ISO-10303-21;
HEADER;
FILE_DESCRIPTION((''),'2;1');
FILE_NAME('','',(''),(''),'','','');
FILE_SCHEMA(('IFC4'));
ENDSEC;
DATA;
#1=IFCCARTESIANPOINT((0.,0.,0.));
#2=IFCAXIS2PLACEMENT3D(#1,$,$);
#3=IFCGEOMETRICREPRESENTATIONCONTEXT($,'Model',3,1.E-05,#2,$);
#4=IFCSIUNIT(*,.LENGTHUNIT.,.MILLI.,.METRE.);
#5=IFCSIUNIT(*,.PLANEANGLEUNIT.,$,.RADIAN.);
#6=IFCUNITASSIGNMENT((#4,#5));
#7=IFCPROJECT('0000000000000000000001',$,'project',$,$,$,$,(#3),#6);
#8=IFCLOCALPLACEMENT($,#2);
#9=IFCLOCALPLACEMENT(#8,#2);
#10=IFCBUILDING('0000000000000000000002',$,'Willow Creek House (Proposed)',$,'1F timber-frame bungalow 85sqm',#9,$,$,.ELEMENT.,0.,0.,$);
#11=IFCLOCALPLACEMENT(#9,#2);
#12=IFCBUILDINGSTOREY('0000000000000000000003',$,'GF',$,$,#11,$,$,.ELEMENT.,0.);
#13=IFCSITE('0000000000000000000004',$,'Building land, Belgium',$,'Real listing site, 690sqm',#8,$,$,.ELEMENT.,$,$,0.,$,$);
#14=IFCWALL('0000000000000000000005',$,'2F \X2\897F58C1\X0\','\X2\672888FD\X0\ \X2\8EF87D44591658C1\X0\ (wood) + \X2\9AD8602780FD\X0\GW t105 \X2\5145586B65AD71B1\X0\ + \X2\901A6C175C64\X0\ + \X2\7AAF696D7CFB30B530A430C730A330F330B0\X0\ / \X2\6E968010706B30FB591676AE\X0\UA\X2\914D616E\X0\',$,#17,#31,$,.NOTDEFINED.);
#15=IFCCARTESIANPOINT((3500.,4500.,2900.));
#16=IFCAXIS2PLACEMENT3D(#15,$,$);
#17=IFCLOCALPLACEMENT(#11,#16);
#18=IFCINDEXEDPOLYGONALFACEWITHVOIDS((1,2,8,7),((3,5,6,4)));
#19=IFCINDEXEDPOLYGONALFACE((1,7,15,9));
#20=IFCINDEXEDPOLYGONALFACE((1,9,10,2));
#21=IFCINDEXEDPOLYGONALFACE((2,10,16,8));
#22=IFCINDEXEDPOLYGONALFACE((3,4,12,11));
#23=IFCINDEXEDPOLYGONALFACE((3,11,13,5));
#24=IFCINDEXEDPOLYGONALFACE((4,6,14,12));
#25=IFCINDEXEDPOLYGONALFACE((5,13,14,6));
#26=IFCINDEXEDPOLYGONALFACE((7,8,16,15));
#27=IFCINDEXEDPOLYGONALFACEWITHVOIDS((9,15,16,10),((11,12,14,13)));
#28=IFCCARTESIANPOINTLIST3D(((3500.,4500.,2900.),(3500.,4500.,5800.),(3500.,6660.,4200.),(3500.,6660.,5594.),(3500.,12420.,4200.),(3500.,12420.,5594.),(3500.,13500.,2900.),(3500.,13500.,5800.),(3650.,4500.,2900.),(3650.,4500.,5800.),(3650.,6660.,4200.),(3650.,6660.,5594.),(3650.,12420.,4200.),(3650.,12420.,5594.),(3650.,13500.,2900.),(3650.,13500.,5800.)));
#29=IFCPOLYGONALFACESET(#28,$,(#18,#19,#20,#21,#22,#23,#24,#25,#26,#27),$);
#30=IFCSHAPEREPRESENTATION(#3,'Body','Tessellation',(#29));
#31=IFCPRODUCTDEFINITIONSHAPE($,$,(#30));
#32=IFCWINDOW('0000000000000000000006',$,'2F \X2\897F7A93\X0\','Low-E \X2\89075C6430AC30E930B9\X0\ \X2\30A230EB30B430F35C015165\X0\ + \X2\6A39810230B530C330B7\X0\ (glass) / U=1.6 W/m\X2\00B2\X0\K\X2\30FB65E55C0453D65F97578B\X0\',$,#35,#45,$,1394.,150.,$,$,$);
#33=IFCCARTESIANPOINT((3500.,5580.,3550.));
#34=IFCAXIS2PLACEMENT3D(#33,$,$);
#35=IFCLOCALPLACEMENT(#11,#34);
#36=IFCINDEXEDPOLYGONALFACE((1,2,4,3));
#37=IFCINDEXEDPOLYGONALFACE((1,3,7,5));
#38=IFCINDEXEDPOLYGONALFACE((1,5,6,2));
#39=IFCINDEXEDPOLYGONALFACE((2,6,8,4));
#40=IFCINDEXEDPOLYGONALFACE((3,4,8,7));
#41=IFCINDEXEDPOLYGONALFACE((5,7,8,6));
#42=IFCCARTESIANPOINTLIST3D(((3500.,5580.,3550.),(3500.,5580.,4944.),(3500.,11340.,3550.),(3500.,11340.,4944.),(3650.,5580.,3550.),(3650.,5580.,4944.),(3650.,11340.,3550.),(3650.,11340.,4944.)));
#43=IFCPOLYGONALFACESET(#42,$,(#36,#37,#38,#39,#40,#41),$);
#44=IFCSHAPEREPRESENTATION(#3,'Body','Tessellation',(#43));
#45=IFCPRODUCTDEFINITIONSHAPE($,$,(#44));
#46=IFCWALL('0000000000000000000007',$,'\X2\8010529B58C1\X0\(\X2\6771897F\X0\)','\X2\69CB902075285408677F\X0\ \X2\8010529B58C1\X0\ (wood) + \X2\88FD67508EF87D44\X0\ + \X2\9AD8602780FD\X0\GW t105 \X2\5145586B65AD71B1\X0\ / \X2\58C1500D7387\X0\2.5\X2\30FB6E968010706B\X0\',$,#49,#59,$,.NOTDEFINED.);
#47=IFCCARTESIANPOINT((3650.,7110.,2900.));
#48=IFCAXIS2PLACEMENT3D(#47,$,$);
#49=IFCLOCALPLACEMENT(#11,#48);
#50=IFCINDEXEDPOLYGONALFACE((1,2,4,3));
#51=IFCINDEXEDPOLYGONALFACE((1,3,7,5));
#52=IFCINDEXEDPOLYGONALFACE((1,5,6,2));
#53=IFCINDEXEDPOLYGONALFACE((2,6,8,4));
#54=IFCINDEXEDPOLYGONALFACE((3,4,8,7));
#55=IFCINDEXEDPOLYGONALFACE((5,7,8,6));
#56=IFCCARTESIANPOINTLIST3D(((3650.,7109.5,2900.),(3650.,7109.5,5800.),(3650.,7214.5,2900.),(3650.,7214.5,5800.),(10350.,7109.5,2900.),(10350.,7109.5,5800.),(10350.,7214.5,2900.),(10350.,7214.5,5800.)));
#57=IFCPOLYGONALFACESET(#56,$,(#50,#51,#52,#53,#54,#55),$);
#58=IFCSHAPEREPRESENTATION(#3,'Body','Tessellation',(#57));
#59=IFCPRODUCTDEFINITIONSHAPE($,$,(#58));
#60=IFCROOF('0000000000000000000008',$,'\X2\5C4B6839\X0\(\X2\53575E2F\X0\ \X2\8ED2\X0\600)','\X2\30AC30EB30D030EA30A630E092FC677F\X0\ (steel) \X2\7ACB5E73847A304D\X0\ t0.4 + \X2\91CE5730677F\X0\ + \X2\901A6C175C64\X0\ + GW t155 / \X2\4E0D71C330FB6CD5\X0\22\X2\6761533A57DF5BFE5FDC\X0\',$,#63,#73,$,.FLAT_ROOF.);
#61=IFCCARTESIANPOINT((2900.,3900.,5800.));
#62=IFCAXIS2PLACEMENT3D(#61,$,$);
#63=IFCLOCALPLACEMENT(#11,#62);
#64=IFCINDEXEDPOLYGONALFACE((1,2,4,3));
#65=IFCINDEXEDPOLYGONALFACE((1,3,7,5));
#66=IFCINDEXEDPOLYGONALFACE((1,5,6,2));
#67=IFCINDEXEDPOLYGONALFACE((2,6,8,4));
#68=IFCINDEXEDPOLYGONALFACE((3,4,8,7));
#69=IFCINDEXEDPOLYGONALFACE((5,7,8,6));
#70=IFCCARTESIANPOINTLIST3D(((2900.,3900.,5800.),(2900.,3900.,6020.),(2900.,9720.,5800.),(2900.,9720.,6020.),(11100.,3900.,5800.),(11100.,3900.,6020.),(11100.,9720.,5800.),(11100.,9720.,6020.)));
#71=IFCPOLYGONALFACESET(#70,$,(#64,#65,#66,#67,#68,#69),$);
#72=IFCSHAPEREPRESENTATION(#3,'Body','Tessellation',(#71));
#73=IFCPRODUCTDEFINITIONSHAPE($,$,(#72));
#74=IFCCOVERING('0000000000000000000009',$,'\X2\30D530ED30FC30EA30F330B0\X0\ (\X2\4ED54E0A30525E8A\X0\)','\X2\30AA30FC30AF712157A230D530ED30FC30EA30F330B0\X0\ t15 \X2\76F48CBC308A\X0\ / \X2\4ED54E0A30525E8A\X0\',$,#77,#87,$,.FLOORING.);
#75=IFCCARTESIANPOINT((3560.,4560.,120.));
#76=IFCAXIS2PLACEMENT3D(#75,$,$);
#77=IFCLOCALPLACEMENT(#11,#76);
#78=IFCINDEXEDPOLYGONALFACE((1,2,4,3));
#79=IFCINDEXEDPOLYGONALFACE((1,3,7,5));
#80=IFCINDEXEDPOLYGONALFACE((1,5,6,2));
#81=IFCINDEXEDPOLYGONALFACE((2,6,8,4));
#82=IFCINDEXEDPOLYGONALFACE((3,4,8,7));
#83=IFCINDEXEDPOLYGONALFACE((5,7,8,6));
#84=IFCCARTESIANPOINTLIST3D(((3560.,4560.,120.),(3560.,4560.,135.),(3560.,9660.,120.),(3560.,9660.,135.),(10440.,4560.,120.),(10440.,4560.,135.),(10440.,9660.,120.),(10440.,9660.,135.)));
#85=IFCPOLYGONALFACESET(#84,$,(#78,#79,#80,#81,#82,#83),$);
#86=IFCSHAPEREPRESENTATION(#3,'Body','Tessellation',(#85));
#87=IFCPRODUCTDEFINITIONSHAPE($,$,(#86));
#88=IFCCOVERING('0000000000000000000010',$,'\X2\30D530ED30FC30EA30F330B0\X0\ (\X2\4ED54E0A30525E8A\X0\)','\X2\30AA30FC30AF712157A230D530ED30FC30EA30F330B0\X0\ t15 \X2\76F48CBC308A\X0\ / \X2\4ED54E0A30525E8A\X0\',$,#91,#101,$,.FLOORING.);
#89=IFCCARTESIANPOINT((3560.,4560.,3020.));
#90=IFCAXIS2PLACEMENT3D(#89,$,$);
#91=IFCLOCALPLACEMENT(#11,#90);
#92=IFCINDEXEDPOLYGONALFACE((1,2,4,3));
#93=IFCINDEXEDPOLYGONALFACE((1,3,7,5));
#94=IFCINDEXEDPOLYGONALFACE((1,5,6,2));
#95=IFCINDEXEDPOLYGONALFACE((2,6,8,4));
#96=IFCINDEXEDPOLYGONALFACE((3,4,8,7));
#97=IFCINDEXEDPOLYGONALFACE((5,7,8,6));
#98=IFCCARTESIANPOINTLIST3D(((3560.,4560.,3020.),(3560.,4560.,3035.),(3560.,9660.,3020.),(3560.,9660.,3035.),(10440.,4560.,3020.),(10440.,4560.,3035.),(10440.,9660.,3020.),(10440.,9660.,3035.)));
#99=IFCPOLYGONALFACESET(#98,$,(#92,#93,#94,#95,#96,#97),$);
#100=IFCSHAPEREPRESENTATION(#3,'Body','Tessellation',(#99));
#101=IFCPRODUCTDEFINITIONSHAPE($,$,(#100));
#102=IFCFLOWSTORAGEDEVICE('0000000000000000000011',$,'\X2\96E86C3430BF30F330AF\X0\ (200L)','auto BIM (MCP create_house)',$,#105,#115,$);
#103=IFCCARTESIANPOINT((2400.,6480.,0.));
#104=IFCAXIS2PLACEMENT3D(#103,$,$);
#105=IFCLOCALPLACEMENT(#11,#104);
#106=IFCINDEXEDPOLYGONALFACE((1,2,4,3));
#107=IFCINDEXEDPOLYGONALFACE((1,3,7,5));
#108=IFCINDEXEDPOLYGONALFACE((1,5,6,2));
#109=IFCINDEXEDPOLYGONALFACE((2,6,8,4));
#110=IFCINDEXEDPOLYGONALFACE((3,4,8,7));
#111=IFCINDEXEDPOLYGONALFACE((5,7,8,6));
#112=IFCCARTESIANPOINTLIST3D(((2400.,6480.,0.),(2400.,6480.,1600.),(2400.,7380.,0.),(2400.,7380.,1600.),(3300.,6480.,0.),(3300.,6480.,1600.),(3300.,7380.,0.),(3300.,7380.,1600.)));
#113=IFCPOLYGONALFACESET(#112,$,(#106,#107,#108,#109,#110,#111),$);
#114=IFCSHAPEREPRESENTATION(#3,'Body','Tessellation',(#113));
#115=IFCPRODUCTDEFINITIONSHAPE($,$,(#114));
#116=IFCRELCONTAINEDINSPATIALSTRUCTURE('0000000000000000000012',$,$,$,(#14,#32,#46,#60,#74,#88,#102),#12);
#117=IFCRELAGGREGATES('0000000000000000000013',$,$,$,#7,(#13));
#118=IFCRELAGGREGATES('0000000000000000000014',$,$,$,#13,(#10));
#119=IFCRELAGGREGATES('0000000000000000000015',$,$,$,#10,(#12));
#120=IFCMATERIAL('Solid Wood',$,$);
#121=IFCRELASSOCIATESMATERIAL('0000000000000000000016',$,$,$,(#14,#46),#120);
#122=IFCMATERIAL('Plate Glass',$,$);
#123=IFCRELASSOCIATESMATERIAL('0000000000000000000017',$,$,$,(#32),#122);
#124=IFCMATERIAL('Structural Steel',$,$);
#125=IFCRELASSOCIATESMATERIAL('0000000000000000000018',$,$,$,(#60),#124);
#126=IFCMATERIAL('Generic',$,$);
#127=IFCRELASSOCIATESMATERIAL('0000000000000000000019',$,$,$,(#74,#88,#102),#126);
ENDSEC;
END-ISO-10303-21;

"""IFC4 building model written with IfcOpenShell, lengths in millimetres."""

from ifc_helpers import new_model, si_unit, frame, frame_2d, origin, place, context, project, spatial, rectangle, extrude, material, element, fill, save


model = new_model("IFC4")

# Units and contexts
model_context = context("Model", 3, precision=1e-05, world=origin())
ifc_project = project(units=[si_unit("LENGTHUNIT", "METRE", prefix="MILLI"), si_unit("PLANEANGLEUNIT", "RADIAN")], contexts=[model_context])

# Site, building, storey
site_placement = place(None, origin())
site = spatial("IfcSite", under=ifc_project, at=site_placement, Name="Building land, Belgium", ObjectType="Real listing site, 690sqm", CompositionType="ELEMENT", RefElevation=0.0)
building_placement = place(site_placement, origin())
building = spatial("IfcBuilding", under=site, at=building_placement, Name="Willow Creek House (Proposed)", ObjectType="1F timber-frame bungalow 85sqm", CompositionType="ELEMENT", ElevationOfRefHeight=0.0, ElevationOfTerrain=0.0)
storey_placement = place(building_placement, origin())
storey = spatial("IfcBuildingStorey", under=building, at=storey_placement, Name="GF", CompositionType="ELEMENT", Elevation=0.0)

# Shared definitions
ifc_material_1 = material(Name="Solid Wood")
ifc_material_2 = material(Name="Generic")

# Shared definitions
ifc_material_3 = material(Name="Plate Glass")

# Wall, opening, window
wall_1_placement = place(storey_placement, frame((3500.0, 4500.0, 2900.0)))
wall_1 = element("IfcWall", 1, at=wall_1_placement, inside=storey, material=ifc_material_1, Name="2F 西壁", Description="木製 軸組外壁 (wood) + 高性能GW t105 充填断熱 + 通気層 + 窯業系サイディング / 準耐火・外皮UA配慮", PredefinedType="NOTDEFINED", context=model_context, shape_type="SweptSolid", body=[
    extrude(rectangle(XDim=150.0, YDim=9000.0, at=frame_2d((75.0, 4500.0))), frame((3500.0, 4500.0, 2900.0)), (0.0, 0.0, 1.0), 2900.0),
])
opening_1_placement = place(storey_placement, frame((3500.0, 5580.0, 3550.0)))
opening_1 = element("IfcOpeningElement", 2, at=opening_1_placement, cuts=wall_1, PredefinedType="NOTDEFINED", context=model_context, shape_type="SweptSolid", body=[
    extrude(rectangle(XDim=150.0, YDim=5760.0, at=frame_2d((75.0, 2880.0))), frame((3500.0, 5580.0, 3550.0)), (0.0, 0.0, 1.0), 1394.0),
])
window_1_placement = place(storey_placement, frame((3500.0, 5580.0, 3550.0)))
window_1 = element("IfcWindow", 3, at=window_1_placement, inside=storey, material=ifc_material_3, Name="2F 西窓", Description="Low-E 複層ガラス アルゴン封入 + 樹脂サッシ (glass) / U=1.6 W/m²K・日射取得型", OverallHeight=1394.0, OverallWidth=150.0, context=model_context, shape_type="SweptSolid", body=[
    extrude(rectangle(XDim=150.0, YDim=5760.0, at=frame_2d((75.0, 2880.0))), frame((3500.0, 5580.0, 3550.0)), (0.0, 0.0, 1.0), 1394.0),
])
fill(opening_1, window_1)

# Wall
wall_2_placement = place(storey_placement, frame((3650.0, 7110.0, 2900.0)))
element("IfcWall", 4, at=wall_2_placement, inside=storey, material=ifc_material_1, Name="耐力壁(東西)", Description="構造用合板 耐力壁 (wood) + 製材軸組 + 高性能GW t105 充填断熱 / 壁倍率2.5・準耐火", PredefinedType="NOTDEFINED", context=model_context, shape_type="SweptSolid", body=[
    extrude(rectangle(XDim=6700.0, YDim=105.0, at=frame_2d((3350.0, 52.0))), frame((3650.0, 7110.0, 2900.0)), (0.0, 0.0, 1.0), 2900.0),
])

# Roof
ifc_material_4 = material(Name="Structural Steel")
for number, where, name in (
    (5, (2900.0, 3900.0, 5800.0), "屋根(南帯 軒600)"),
):
    element("IfcRoof", number, at=place(storey_placement, frame(where)), inside=storey, material=ifc_material_4, Name=name, Description="ガルバリウム鋼板 (steel) 立平葺き t0.4 + 野地板 + 通気層 + GW t155 / 不燃・法22条区域対応", PredefinedType="FLAT_ROOF", context=model_context, shape_type="SweptSolid", body=[
        extrude(rectangle(XDim=8200.0, YDim=5820.0, at=frame_2d((4100.0, 2910.0))), frame((2900.0, 3900.0, 5800.0)), (0.0, 0.0, 1.0), 220.0),
    ])

# Coverings
covering_1_placement = place(storey_placement, frame((3560.0, 4560.0, 120.0)))
element("IfcCovering", 6, at=covering_1_placement, inside=storey, material=ifc_material_2, Name="フローリング (仕上げ床)", Description="オーク無垢フローリング t15 直貼り / 仕上げ床", PredefinedType="FLOORING", context=model_context, shape_type="SweptSolid", body=[
    extrude(rectangle(XDim=6880.0, YDim=5100.0, at=frame_2d((3440.0, 2550.0))), frame((3560.0, 4560.0, 120.0)), (0.0, 0.0, 1.0), 15.0),
])
covering_2_placement = place(storey_placement, frame((3560.0, 4560.0, 3020.0)))
element("IfcCovering", 7, at=covering_2_placement, inside=storey, material=ifc_material_2, Name="フローリング (仕上げ床)", Description="オーク無垢フローリング t15 直貼り / 仕上げ床", PredefinedType="FLOORING", context=model_context, shape_type="SweptSolid", body=[
    extrude(rectangle(XDim=6880.0, YDim=5100.0, at=frame_2d((3440.0, 2550.0))), frame((3560.0, 4560.0, 3020.0)), (0.0, 0.0, 1.0), 15.0),
])

# Flow storage device
flow_storage_device_placement = place(storey_placement, frame((2400.0, 6480.0, 0.0)))
element("IfcFlowStorageDevice", 8, at=flow_storage_device_placement, inside=storey, material=ifc_material_2, Name="雨水タンク (200L)", Description="auto BIM (MCP create_house)", context=model_context, shape_type="SweptSolid", body=[
    extrude(rectangle(XDim=900.0, YDim=900.0, at=frame_2d((450.0, 450.0))), frame((2400.0, 6480.0, 0.0)), (0.0, 0.0, 1.0), 1600.0),
])

save(model, "model.ifc")
